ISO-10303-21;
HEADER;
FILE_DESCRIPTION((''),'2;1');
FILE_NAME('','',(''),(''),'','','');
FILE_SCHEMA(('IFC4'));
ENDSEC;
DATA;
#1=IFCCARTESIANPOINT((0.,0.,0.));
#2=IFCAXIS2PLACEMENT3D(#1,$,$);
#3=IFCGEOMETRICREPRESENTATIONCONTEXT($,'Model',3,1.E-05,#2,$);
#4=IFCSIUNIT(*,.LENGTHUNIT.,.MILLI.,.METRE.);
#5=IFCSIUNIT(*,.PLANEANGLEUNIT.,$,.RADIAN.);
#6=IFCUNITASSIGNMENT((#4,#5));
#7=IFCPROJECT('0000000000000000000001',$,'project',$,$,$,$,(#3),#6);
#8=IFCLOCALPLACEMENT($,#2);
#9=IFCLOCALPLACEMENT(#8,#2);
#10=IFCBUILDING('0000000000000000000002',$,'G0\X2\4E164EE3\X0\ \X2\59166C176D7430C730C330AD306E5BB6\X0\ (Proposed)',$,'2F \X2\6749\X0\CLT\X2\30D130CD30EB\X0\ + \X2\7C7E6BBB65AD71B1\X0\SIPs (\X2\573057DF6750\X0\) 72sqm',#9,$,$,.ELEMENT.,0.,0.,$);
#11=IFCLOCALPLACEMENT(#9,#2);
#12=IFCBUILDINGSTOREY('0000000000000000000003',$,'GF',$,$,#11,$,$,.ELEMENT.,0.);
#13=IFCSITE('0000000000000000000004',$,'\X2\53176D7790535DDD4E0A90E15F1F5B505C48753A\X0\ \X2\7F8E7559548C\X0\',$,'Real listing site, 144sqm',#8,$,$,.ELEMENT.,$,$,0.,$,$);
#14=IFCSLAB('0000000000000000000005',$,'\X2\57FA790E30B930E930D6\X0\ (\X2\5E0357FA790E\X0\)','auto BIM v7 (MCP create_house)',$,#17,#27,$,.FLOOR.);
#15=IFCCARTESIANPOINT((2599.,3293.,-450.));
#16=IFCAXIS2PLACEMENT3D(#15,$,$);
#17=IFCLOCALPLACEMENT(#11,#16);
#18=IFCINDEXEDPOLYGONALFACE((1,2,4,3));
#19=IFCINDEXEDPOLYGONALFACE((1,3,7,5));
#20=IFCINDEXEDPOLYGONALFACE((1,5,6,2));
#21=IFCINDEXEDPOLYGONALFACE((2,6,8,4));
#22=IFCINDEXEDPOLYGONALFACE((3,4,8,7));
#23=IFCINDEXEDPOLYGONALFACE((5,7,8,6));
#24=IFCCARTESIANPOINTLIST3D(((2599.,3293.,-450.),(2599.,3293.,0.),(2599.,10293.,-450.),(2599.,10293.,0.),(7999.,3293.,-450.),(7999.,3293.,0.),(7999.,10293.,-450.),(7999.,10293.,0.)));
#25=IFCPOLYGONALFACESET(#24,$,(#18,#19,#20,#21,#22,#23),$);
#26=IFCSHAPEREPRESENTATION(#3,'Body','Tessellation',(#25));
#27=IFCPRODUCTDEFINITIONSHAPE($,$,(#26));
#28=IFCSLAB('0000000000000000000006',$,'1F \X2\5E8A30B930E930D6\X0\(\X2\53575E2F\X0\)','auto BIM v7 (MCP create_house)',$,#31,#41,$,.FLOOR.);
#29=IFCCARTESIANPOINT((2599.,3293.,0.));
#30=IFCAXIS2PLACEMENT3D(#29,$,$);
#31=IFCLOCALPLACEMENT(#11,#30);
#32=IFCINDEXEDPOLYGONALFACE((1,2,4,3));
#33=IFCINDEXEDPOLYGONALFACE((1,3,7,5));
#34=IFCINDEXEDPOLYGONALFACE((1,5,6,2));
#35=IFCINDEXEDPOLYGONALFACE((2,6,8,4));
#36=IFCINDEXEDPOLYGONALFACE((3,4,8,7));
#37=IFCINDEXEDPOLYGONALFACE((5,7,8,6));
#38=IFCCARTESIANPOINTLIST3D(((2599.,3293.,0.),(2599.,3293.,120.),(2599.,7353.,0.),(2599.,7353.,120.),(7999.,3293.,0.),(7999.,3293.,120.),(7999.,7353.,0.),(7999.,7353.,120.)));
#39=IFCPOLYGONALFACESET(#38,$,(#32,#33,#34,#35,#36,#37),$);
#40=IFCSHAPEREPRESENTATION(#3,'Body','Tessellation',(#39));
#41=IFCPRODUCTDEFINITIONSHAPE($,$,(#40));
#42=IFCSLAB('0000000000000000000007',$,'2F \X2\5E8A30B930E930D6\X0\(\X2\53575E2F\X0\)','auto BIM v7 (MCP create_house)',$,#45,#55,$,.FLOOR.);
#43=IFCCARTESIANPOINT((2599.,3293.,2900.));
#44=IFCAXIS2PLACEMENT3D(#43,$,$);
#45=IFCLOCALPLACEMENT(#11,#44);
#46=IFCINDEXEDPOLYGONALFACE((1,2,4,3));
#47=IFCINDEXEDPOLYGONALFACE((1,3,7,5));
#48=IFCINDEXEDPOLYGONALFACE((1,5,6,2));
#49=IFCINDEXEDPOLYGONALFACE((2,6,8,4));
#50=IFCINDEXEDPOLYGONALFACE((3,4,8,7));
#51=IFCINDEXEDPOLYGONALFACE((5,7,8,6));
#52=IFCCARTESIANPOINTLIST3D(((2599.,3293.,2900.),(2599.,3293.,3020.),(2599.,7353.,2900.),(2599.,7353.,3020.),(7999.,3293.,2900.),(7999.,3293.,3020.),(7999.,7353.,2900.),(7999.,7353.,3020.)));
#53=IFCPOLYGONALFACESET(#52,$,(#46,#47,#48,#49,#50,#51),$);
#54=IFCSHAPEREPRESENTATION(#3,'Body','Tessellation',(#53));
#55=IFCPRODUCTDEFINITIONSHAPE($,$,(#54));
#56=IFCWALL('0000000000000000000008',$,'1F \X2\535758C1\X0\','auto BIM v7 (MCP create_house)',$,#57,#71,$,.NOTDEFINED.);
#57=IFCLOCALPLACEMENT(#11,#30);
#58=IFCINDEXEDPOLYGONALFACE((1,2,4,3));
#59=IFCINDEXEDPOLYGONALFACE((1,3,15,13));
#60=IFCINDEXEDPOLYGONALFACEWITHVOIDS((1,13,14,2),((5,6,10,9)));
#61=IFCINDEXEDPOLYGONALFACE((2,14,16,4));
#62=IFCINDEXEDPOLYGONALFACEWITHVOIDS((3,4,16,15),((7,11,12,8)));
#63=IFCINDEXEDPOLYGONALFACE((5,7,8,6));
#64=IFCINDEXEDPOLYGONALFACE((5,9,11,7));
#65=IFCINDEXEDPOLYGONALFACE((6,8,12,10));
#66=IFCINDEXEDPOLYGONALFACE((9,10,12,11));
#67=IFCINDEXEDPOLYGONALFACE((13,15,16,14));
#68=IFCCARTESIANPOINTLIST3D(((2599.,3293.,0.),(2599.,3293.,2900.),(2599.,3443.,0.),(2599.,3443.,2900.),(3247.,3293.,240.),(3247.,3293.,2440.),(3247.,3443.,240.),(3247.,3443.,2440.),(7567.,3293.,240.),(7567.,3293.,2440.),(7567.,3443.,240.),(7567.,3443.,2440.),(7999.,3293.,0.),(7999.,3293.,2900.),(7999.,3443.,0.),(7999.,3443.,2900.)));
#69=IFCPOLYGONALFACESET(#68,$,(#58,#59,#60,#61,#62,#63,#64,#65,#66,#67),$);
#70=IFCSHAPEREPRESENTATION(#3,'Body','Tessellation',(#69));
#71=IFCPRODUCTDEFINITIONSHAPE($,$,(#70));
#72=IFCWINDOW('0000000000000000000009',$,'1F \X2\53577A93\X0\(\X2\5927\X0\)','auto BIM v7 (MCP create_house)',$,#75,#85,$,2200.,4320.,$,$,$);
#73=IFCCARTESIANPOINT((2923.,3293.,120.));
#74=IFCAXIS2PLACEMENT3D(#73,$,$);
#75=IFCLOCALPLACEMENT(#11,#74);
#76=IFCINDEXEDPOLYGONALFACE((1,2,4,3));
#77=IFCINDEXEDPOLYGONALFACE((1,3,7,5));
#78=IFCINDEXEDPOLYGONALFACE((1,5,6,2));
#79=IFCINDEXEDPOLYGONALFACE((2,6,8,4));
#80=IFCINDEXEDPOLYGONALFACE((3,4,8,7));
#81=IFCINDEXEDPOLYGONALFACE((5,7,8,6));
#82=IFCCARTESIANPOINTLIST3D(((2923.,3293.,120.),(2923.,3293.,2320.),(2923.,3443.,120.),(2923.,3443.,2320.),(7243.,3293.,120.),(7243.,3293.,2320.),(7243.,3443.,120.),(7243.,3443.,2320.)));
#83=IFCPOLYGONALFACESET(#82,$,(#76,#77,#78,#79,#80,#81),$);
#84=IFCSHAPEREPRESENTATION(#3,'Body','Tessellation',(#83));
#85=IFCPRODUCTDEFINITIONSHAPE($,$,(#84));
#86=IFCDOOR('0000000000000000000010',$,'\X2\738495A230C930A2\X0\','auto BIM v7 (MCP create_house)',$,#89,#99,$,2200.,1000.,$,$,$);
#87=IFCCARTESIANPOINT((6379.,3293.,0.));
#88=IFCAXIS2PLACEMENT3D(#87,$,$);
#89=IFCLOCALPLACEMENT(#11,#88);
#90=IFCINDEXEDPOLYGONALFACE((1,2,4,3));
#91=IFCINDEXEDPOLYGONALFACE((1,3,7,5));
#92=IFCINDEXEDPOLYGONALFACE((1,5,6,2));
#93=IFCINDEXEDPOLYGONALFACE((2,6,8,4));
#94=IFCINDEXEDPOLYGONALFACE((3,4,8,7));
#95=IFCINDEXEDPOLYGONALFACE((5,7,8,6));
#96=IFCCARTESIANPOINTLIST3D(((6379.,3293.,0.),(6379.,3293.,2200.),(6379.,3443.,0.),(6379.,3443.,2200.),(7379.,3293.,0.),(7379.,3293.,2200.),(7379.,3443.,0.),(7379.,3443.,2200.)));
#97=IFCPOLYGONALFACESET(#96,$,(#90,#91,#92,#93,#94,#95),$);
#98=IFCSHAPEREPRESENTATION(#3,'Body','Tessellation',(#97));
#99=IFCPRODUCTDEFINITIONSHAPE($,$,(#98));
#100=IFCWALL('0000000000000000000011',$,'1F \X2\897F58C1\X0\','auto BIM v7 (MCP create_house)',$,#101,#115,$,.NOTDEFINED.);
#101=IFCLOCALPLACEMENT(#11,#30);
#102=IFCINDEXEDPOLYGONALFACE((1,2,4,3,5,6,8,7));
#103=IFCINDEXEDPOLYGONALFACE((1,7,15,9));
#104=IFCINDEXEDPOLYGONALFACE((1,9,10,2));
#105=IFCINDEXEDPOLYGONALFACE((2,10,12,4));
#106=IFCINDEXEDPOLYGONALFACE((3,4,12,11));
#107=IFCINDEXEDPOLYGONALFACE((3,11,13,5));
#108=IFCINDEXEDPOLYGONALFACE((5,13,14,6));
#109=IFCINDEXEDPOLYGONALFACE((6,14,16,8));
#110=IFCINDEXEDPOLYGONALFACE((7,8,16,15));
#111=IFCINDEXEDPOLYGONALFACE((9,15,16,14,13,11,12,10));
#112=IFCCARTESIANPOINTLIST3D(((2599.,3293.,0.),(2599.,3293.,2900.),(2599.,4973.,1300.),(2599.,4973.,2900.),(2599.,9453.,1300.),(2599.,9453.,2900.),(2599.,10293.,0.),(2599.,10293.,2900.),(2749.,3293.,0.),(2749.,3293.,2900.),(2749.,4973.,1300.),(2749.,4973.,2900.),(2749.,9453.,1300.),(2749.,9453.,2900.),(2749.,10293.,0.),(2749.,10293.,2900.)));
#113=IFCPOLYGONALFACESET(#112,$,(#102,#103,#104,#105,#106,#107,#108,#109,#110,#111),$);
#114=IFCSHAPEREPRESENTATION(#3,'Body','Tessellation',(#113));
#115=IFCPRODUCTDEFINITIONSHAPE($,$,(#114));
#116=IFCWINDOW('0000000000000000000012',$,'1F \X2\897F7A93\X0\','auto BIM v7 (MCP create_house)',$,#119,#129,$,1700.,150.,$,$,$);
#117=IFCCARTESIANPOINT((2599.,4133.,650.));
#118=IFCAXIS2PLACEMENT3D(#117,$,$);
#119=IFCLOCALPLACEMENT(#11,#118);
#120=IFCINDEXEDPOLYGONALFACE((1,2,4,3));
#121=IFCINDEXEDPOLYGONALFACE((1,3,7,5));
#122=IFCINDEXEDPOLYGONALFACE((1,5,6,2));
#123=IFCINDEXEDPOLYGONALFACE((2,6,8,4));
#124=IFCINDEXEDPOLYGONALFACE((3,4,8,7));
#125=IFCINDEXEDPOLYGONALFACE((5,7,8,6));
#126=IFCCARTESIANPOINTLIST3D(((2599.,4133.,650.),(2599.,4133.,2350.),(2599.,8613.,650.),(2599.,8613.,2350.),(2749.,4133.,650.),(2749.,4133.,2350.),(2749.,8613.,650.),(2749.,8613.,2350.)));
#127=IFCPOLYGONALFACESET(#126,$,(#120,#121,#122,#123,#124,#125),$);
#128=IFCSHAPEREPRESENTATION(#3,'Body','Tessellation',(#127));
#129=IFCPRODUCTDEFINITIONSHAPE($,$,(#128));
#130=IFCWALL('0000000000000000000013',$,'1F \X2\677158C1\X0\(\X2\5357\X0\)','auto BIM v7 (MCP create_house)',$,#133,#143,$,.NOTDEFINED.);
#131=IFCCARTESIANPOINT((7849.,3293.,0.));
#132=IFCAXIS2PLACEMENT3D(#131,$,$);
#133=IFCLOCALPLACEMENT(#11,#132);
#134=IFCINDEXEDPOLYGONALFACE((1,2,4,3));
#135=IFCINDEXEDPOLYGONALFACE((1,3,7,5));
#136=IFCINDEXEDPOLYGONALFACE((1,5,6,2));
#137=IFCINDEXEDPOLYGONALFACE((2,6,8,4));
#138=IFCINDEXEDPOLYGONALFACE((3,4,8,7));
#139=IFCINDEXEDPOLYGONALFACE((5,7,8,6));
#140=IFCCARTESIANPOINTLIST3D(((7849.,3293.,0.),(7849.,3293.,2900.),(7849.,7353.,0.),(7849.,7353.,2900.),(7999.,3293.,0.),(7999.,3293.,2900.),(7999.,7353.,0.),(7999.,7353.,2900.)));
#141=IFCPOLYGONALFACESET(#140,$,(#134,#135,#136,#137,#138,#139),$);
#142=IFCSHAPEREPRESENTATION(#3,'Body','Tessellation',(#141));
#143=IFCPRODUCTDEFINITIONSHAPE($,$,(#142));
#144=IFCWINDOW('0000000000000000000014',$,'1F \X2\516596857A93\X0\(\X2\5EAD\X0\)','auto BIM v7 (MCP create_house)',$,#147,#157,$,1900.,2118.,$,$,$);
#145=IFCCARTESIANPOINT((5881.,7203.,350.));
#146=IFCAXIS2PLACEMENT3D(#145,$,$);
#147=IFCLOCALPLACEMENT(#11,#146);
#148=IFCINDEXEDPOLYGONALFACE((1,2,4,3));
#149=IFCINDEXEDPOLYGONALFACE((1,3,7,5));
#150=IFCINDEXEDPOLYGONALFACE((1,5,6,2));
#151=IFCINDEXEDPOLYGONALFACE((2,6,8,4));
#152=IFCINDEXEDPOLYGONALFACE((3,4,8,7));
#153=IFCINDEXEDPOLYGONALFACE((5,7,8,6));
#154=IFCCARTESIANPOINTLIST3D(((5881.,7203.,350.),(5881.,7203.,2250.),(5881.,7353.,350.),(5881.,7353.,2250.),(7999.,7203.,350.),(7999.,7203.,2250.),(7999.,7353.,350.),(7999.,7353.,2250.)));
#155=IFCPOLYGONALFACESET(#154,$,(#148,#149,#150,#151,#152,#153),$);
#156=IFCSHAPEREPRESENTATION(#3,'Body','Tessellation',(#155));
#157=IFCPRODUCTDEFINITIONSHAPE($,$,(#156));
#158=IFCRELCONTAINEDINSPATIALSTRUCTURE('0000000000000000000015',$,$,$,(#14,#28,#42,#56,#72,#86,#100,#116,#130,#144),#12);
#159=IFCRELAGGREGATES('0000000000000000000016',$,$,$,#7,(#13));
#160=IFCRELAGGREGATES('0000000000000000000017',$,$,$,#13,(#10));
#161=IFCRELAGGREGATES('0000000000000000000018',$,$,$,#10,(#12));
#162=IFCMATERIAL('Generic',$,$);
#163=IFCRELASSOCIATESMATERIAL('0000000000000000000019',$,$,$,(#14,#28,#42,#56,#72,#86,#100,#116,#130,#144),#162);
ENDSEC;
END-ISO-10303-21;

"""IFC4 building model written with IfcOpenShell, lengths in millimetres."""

from ifc_helpers import new_model, si_unit, frame, frame_2d, origin, place, context, project, spatial, rectangle, extrude, material, element, fill, save


model = new_model("IFC4")

# Units and contexts
model_context = context("Model", 3, precision=1e-05, world=origin())
ifc_project = project(units=[si_unit("LENGTHUNIT", "METRE", prefix="MILLI"), si_unit("PLANEANGLEUNIT", "RADIAN")], contexts=[model_context])

# Site, building, storey
site_placement = place(None, origin())
site = spatial("IfcSite", under=ifc_project, at=site_placement, Name="北海道川上郡弟子屈町 美留和", ObjectType="Real listing site, 144sqm", CompositionType="ELEMENT", RefElevation=0.0)
building_placement = place(site_placement, origin())
building = spatial("IfcBuilding", under=site, at=building_placement, Name="G0世代 外気浴デッキの家 (Proposed)", ObjectType="2F 杉CLTパネル + 籾殻断熱SIPs (地域材) 72sqm", CompositionType="ELEMENT", ElevationOfRefHeight=0.0, ElevationOfTerrain=0.0)
storey_placement = place(building_placement, origin())
storey = spatial("IfcBuildingStorey", under=building, at=storey_placement, Name="GF", CompositionType="ELEMENT", Elevation=0.0)

# Slabs
ifc_material = material(Name="Generic")
slab_1_placement = place(storey_placement, frame((2599.0, 3293.0, -450.0)))
element("IfcSlab", 1, at=slab_1_placement, inside=storey, material=ifc_material, Name="基礎スラブ (布基礎)", Description="auto BIM v7 (MCP create_house)", PredefinedType="FLOOR", context=model_context, shape_type="SweptSolid", body=[
    extrude(rectangle(XDim=5400.0, YDim=7000.0, at=frame_2d((2700.0, 3500.0))), frame((2599.0, 3293.0, -450.0)), (0.0, 0.0, 1.0), 450.0),
])
slab_2_placement = place(storey_placement, frame((2599.0, 3293.0, 0.0)))
element("IfcSlab", 2, at=slab_2_placement, inside=storey, material=ifc_material, Name="1F 床スラブ(南帯)", Description="auto BIM v7 (MCP create_house)", PredefinedType="FLOOR", context=model_context, shape_type="SweptSolid", body=[
    extrude(rectangle(XDim=5400.0, YDim=4060.0, at=frame_2d((2700.0, 2030.0))), frame((2599.0, 3293.0, 0.0)), (0.0, 0.0, 1.0), 120.0),
])
slab_3_placement = place(storey_placement, frame((2599.0, 3293.0, 2900.0)))
element("IfcSlab", 3, at=slab_3_placement, inside=storey, material=ifc_material, Name="2F 床スラブ(南帯)", Description="auto BIM v7 (MCP create_house)", PredefinedType="FLOOR", context=model_context, shape_type="SweptSolid", body=[
    extrude(rectangle(XDim=5400.0, YDim=4060.0, at=frame_2d((2700.0, 2030.0))), frame((2599.0, 3293.0, 2900.0)), (0.0, 0.0, 1.0), 120.0),
])

# Wall, openings, window, door
wall_1_placement = place(storey_placement, frame((2599.0, 3293.0, 0.0)))
wall_1 = element("IfcWall", 4, at=wall_1_placement, inside=storey, material=ifc_material, Name="1F 南壁", Description="auto BIM v7 (MCP create_house)", PredefinedType="NOTDEFINED", context=model_context, shape_type="SweptSolid", body=[
    extrude(rectangle(XDim=5400.0, YDim=150.0, at=frame_2d((2700.0, 75.0))), frame((2599.0, 3293.0, 0.0)), (0.0, 0.0, 1.0), 2900.0),
])
opening_1_placement = place(storey_placement, frame((2923.0, 3293.0, 120.0)))
opening_1 = element("IfcOpeningElement", 5, at=opening_1_placement, cuts=wall_1, PredefinedType="NOTDEFINED", context=model_context, shape_type="SweptSolid", body=[
    extrude(rectangle(XDim=4320.0, YDim=150.0, at=frame_2d((2160.0, 75.0))), frame((2923.0, 3293.0, 120.0)), (0.0, 0.0, 1.0), 2200.0),
])
opening_2_placement = place(storey_placement, frame((6379.0, 3293.0, 0.0)))
opening_2 = element("IfcOpeningElement", 6, at=opening_2_placement, cuts=wall_1, PredefinedType="NOTDEFINED", context=model_context, shape_type="SweptSolid", body=[
    extrude(rectangle(XDim=1000.0, YDim=150.0, at=frame_2d((500.0, 75.0))), frame((6379.0, 3293.0, 0.0)), (0.0, 0.0, 1.0), 2200.0),
])
window_1_placement = place(storey_placement, frame((2923.0, 3293.0, 120.0)))
window_1 = element("IfcWindow", 7, at=window_1_placement, inside=storey, material=ifc_material, Name="1F 南窓(大)", Description="auto BIM v7 (MCP create_house)", OverallHeight=2200.0, OverallWidth=4320.0, context=model_context, shape_type="SweptSolid", body=[
    extrude(rectangle(XDim=4320.0, YDim=150.0, at=frame_2d((2160.0, 75.0))), frame((2923.0, 3293.0, 120.0)), (0.0, 0.0, 1.0), 2200.0),
])
fill(opening_1, window_1)
door_placement = place(storey_placement, frame((6379.0, 3293.0, 0.0)))
door = element("IfcDoor", 8, at=door_placement, inside=storey, material=ifc_material, Name="玄関ドア", Description="auto BIM v7 (MCP create_house)", OverallHeight=2200.0, OverallWidth=1000.0, context=model_context, shape_type="SweptSolid", body=[
    extrude(rectangle(XDim=1000.0, YDim=150.0, at=frame_2d((500.0, 75.0))), frame((6379.0, 3293.0, 0.0)), (0.0, 0.0, 1.0), 2200.0),
])
fill(opening_2, door)

# Walls, openings, windows
wall_2_placement = place(storey_placement, frame((2599.0, 3293.0, 0.0)))
wall_2 = element("IfcWall", 9, at=wall_2_placement, inside=storey, material=ifc_material, Name="1F 西壁", Description="auto BIM v7 (MCP create_house)", PredefinedType="NOTDEFINED", context=model_context, shape_type="SweptSolid", body=[
    extrude(rectangle(XDim=150.0, YDim=7000.0, at=frame_2d((75.0, 3500.0))), frame((2599.0, 3293.0, 0.0)), (0.0, 0.0, 1.0), 2900.0),
])
opening_3_placement = place(storey_placement, frame((2599.0, 4133.0, 650.0)))
opening_3 = element("IfcOpeningElement", 10, at=opening_3_placement, cuts=wall_2, PredefinedType="NOTDEFINED", context=model_context, shape_type="SweptSolid", body=[
    extrude(rectangle(XDim=150.0, YDim=4480.0, at=frame_2d((75.0, 2240.0))), frame((2599.0, 4133.0, 650.0)), (0.0, 0.0, 1.0), 1700.0),
])
window_2_placement = place(storey_placement, frame((2599.0, 4133.0, 650.0)))
window_2 = element("IfcWindow", 11, at=window_2_placement, inside=storey, material=ifc_material, Name="1F 西窓", Description="auto BIM v7 (MCP create_house)", OverallHeight=1700.0, OverallWidth=150.0, context=model_context, shape_type="SweptSolid", body=[
    extrude(rectangle(XDim=150.0, YDim=4480.0, at=frame_2d((75.0, 2240.0))), frame((2599.0, 4133.0, 650.0)), (0.0, 0.0, 1.0), 1700.0),
])
fill(opening_3, window_2)
wall_3_placement = place(storey_placement, frame((7849.0, 3293.0, 0.0)))
wall_3 = element("IfcWall", 12, at=wall_3_placement, inside=storey, material=ifc_material, Name="1F 東壁(南)", Description="auto BIM v7 (MCP create_house)", PredefinedType="NOTDEFINED", context=model_context, shape_type="SweptSolid", body=[
    extrude(rectangle(XDim=150.0, YDim=4060.0, at=frame_2d((75.0, 2030.0))), frame((7849.0, 3293.0, 0.0)), (0.0, 0.0, 1.0), 2900.0),
])
opening_4_placement = place(storey_placement, frame((5881.0, 7203.0, 350.0)))
opening_4 = element("IfcOpeningElement", 13, at=opening_4_placement, cuts=wall_3, PredefinedType="NOTDEFINED", context=model_context, shape_type="SweptSolid", body=[
    extrude(rectangle(XDim=2118.0, YDim=150.0, at=frame_2d((1059.0, 75.0))), frame((5881.0, 7203.0, 350.0)), (0.0, 0.0, 1.0), 1900.0),
])
window_3_placement = place(storey_placement, frame((5881.0, 7203.0, 350.0)))
window_3 = element("IfcWindow", 14, at=window_3_placement, inside=storey, material=ifc_material, Name="1F 入隅窓(庭)", Description="auto BIM v7 (MCP create_house)", OverallHeight=1900.0, OverallWidth=2118.0, context=model_context, shape_type="SweptSolid", body=[
    extrude(rectangle(XDim=2118.0, YDim=150.0, at=frame_2d((1059.0, 75.0))), frame((5881.0, 7203.0, 350.0)), (0.0, 0.0, 1.0), 1900.0),
])
fill(opening_4, window_3)

save(model, "model.ifc")
